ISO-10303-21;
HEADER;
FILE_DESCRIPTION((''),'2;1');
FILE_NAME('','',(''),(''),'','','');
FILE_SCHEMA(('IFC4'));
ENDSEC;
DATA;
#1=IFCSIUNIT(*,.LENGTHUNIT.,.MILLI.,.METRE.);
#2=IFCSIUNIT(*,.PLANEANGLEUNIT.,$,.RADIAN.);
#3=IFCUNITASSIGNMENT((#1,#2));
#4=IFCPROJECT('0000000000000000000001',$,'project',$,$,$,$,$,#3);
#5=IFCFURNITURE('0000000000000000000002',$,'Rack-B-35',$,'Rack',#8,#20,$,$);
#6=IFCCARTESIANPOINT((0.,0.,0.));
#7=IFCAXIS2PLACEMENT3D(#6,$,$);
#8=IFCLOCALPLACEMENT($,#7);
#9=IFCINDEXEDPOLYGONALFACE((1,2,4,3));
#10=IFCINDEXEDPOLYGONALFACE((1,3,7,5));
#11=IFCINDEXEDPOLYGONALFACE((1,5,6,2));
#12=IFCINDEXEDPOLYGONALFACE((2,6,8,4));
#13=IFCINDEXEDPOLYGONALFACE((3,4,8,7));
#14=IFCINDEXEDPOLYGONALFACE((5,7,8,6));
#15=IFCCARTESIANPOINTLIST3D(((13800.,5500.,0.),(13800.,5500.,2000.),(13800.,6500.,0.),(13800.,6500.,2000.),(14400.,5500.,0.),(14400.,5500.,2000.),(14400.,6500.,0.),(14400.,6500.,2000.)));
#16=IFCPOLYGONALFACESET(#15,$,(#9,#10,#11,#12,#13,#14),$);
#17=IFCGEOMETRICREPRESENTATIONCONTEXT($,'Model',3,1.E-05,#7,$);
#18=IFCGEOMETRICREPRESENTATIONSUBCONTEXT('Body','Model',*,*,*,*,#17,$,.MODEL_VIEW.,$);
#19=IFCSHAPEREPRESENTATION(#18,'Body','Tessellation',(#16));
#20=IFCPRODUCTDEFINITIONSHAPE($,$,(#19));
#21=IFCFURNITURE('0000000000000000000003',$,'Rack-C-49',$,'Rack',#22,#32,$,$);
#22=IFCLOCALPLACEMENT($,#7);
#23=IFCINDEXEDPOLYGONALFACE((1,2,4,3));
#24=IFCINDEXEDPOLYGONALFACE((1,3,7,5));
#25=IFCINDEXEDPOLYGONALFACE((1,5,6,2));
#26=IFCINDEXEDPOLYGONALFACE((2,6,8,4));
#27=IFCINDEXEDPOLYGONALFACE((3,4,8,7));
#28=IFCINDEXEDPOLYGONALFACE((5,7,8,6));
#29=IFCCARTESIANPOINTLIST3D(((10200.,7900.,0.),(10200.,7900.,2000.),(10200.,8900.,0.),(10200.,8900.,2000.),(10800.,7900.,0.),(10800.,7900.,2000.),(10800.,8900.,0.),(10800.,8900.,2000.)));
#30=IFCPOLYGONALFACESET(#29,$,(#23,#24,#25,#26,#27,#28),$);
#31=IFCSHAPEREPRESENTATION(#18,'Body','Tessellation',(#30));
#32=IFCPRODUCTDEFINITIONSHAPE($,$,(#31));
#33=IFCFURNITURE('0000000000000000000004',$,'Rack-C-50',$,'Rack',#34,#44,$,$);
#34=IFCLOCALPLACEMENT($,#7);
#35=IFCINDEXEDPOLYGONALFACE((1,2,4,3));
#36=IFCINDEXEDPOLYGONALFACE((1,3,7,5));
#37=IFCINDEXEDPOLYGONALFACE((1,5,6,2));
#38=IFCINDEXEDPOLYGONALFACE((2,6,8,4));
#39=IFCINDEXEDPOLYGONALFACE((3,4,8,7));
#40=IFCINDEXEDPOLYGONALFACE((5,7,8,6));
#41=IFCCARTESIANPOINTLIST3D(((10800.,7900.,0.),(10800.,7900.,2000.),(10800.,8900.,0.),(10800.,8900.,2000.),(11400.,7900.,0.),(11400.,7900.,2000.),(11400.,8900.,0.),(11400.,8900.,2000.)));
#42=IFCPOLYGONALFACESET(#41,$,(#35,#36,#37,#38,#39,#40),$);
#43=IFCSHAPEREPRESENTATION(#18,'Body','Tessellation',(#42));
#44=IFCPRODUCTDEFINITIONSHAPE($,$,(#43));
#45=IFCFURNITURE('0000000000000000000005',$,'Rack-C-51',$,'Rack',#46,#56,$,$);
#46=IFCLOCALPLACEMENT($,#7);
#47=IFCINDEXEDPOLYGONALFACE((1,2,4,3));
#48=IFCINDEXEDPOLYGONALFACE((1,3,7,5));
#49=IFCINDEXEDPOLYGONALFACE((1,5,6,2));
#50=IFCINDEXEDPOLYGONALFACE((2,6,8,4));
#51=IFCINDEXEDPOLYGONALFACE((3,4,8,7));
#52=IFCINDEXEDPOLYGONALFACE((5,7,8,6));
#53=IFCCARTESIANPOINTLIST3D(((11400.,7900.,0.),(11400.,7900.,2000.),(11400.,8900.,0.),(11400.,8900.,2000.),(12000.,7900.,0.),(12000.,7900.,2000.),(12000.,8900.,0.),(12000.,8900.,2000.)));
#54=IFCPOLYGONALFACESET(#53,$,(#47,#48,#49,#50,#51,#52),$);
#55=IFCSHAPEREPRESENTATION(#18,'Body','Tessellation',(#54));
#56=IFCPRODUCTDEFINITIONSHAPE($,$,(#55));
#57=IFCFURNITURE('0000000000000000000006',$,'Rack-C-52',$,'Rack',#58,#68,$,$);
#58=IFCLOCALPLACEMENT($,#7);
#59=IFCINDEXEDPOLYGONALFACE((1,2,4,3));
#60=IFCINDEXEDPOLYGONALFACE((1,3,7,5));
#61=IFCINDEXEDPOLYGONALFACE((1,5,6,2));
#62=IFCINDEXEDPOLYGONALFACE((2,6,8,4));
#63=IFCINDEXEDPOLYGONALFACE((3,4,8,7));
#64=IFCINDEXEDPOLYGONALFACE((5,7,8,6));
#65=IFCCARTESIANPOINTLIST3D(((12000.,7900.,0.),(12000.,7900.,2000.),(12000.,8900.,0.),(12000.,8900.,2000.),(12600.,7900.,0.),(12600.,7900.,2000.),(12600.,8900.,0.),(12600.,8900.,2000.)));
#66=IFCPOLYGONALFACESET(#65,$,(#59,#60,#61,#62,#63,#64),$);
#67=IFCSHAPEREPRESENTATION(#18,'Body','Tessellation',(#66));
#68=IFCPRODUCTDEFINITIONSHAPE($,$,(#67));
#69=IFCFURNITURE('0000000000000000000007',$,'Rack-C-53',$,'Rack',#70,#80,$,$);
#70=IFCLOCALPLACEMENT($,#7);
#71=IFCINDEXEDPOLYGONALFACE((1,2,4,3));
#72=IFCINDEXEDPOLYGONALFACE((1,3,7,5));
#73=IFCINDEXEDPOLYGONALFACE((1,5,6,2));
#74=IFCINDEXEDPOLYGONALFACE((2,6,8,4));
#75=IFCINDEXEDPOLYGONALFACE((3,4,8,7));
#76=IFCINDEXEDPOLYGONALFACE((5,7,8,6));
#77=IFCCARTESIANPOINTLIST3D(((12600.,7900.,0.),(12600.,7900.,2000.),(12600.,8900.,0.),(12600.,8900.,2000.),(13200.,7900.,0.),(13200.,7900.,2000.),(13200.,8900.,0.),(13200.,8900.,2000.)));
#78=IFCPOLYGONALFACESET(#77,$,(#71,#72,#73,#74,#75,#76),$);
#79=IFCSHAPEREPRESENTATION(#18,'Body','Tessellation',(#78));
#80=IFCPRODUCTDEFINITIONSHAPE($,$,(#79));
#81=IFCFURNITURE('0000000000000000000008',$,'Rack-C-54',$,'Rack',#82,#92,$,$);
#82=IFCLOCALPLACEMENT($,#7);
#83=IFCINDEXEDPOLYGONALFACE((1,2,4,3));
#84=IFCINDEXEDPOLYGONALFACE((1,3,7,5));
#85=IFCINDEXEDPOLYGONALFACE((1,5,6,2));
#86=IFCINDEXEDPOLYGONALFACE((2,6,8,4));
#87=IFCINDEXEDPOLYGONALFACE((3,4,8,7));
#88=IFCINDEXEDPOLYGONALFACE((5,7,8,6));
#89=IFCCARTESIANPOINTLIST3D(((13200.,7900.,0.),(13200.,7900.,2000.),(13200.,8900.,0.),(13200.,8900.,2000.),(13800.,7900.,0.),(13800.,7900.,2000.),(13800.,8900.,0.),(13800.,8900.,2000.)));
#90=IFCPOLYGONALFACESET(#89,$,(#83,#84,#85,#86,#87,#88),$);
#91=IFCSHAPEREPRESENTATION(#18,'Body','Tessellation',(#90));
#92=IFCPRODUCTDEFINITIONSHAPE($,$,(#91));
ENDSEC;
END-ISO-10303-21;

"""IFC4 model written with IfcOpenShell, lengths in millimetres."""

from ifc_helpers import new_model, si_unit, frame, origin, place, context, subcontext, project, rectangle, extrude, element, save


model = new_model("IFC4")

# Units and contexts
model_context = context("Model", 3, precision=1e-05, world=origin())
body_context = subcontext(model_context, "Body", "Model", "MODEL_VIEW")
ifc_project = project(units=[si_unit("LENGTHUNIT", "METRE", prefix="MILLI"), si_unit("PLANEANGLEUNIT", "RADIAN")])

# Furniture
for number, where, name in (
    (1, (14100.0, 6000.0, 0.0), "Rack-B-35"),
    (2, (10500.0, 8400.0, 0.0), "Rack-C-49"),
    (3, (11100.0, 8400.0, 0.0), "Rack-C-50"),
    (4, (11700.0, 8400.0, 0.0), "Rack-C-51"),
    (5, (12300.0, 8400.0, 0.0), "Rack-C-52"),
    (6, (12900.0, 8400.0, 0.0), "Rack-C-53"),
    (7, (13500.0, 8400.0, 0.0), "Rack-C-54"),
):
    element("IfcFurniture", number, at=place(None, frame(where)), Name=name, ObjectType="Rack", context=body_context, shape_type="SweptSolid", body=[
        extrude(rectangle(XDim=600.0, YDim=1000.0), None, (0.0, 0.0, 1.0), 2000.0),
    ])

save(model, "model.ifc")
